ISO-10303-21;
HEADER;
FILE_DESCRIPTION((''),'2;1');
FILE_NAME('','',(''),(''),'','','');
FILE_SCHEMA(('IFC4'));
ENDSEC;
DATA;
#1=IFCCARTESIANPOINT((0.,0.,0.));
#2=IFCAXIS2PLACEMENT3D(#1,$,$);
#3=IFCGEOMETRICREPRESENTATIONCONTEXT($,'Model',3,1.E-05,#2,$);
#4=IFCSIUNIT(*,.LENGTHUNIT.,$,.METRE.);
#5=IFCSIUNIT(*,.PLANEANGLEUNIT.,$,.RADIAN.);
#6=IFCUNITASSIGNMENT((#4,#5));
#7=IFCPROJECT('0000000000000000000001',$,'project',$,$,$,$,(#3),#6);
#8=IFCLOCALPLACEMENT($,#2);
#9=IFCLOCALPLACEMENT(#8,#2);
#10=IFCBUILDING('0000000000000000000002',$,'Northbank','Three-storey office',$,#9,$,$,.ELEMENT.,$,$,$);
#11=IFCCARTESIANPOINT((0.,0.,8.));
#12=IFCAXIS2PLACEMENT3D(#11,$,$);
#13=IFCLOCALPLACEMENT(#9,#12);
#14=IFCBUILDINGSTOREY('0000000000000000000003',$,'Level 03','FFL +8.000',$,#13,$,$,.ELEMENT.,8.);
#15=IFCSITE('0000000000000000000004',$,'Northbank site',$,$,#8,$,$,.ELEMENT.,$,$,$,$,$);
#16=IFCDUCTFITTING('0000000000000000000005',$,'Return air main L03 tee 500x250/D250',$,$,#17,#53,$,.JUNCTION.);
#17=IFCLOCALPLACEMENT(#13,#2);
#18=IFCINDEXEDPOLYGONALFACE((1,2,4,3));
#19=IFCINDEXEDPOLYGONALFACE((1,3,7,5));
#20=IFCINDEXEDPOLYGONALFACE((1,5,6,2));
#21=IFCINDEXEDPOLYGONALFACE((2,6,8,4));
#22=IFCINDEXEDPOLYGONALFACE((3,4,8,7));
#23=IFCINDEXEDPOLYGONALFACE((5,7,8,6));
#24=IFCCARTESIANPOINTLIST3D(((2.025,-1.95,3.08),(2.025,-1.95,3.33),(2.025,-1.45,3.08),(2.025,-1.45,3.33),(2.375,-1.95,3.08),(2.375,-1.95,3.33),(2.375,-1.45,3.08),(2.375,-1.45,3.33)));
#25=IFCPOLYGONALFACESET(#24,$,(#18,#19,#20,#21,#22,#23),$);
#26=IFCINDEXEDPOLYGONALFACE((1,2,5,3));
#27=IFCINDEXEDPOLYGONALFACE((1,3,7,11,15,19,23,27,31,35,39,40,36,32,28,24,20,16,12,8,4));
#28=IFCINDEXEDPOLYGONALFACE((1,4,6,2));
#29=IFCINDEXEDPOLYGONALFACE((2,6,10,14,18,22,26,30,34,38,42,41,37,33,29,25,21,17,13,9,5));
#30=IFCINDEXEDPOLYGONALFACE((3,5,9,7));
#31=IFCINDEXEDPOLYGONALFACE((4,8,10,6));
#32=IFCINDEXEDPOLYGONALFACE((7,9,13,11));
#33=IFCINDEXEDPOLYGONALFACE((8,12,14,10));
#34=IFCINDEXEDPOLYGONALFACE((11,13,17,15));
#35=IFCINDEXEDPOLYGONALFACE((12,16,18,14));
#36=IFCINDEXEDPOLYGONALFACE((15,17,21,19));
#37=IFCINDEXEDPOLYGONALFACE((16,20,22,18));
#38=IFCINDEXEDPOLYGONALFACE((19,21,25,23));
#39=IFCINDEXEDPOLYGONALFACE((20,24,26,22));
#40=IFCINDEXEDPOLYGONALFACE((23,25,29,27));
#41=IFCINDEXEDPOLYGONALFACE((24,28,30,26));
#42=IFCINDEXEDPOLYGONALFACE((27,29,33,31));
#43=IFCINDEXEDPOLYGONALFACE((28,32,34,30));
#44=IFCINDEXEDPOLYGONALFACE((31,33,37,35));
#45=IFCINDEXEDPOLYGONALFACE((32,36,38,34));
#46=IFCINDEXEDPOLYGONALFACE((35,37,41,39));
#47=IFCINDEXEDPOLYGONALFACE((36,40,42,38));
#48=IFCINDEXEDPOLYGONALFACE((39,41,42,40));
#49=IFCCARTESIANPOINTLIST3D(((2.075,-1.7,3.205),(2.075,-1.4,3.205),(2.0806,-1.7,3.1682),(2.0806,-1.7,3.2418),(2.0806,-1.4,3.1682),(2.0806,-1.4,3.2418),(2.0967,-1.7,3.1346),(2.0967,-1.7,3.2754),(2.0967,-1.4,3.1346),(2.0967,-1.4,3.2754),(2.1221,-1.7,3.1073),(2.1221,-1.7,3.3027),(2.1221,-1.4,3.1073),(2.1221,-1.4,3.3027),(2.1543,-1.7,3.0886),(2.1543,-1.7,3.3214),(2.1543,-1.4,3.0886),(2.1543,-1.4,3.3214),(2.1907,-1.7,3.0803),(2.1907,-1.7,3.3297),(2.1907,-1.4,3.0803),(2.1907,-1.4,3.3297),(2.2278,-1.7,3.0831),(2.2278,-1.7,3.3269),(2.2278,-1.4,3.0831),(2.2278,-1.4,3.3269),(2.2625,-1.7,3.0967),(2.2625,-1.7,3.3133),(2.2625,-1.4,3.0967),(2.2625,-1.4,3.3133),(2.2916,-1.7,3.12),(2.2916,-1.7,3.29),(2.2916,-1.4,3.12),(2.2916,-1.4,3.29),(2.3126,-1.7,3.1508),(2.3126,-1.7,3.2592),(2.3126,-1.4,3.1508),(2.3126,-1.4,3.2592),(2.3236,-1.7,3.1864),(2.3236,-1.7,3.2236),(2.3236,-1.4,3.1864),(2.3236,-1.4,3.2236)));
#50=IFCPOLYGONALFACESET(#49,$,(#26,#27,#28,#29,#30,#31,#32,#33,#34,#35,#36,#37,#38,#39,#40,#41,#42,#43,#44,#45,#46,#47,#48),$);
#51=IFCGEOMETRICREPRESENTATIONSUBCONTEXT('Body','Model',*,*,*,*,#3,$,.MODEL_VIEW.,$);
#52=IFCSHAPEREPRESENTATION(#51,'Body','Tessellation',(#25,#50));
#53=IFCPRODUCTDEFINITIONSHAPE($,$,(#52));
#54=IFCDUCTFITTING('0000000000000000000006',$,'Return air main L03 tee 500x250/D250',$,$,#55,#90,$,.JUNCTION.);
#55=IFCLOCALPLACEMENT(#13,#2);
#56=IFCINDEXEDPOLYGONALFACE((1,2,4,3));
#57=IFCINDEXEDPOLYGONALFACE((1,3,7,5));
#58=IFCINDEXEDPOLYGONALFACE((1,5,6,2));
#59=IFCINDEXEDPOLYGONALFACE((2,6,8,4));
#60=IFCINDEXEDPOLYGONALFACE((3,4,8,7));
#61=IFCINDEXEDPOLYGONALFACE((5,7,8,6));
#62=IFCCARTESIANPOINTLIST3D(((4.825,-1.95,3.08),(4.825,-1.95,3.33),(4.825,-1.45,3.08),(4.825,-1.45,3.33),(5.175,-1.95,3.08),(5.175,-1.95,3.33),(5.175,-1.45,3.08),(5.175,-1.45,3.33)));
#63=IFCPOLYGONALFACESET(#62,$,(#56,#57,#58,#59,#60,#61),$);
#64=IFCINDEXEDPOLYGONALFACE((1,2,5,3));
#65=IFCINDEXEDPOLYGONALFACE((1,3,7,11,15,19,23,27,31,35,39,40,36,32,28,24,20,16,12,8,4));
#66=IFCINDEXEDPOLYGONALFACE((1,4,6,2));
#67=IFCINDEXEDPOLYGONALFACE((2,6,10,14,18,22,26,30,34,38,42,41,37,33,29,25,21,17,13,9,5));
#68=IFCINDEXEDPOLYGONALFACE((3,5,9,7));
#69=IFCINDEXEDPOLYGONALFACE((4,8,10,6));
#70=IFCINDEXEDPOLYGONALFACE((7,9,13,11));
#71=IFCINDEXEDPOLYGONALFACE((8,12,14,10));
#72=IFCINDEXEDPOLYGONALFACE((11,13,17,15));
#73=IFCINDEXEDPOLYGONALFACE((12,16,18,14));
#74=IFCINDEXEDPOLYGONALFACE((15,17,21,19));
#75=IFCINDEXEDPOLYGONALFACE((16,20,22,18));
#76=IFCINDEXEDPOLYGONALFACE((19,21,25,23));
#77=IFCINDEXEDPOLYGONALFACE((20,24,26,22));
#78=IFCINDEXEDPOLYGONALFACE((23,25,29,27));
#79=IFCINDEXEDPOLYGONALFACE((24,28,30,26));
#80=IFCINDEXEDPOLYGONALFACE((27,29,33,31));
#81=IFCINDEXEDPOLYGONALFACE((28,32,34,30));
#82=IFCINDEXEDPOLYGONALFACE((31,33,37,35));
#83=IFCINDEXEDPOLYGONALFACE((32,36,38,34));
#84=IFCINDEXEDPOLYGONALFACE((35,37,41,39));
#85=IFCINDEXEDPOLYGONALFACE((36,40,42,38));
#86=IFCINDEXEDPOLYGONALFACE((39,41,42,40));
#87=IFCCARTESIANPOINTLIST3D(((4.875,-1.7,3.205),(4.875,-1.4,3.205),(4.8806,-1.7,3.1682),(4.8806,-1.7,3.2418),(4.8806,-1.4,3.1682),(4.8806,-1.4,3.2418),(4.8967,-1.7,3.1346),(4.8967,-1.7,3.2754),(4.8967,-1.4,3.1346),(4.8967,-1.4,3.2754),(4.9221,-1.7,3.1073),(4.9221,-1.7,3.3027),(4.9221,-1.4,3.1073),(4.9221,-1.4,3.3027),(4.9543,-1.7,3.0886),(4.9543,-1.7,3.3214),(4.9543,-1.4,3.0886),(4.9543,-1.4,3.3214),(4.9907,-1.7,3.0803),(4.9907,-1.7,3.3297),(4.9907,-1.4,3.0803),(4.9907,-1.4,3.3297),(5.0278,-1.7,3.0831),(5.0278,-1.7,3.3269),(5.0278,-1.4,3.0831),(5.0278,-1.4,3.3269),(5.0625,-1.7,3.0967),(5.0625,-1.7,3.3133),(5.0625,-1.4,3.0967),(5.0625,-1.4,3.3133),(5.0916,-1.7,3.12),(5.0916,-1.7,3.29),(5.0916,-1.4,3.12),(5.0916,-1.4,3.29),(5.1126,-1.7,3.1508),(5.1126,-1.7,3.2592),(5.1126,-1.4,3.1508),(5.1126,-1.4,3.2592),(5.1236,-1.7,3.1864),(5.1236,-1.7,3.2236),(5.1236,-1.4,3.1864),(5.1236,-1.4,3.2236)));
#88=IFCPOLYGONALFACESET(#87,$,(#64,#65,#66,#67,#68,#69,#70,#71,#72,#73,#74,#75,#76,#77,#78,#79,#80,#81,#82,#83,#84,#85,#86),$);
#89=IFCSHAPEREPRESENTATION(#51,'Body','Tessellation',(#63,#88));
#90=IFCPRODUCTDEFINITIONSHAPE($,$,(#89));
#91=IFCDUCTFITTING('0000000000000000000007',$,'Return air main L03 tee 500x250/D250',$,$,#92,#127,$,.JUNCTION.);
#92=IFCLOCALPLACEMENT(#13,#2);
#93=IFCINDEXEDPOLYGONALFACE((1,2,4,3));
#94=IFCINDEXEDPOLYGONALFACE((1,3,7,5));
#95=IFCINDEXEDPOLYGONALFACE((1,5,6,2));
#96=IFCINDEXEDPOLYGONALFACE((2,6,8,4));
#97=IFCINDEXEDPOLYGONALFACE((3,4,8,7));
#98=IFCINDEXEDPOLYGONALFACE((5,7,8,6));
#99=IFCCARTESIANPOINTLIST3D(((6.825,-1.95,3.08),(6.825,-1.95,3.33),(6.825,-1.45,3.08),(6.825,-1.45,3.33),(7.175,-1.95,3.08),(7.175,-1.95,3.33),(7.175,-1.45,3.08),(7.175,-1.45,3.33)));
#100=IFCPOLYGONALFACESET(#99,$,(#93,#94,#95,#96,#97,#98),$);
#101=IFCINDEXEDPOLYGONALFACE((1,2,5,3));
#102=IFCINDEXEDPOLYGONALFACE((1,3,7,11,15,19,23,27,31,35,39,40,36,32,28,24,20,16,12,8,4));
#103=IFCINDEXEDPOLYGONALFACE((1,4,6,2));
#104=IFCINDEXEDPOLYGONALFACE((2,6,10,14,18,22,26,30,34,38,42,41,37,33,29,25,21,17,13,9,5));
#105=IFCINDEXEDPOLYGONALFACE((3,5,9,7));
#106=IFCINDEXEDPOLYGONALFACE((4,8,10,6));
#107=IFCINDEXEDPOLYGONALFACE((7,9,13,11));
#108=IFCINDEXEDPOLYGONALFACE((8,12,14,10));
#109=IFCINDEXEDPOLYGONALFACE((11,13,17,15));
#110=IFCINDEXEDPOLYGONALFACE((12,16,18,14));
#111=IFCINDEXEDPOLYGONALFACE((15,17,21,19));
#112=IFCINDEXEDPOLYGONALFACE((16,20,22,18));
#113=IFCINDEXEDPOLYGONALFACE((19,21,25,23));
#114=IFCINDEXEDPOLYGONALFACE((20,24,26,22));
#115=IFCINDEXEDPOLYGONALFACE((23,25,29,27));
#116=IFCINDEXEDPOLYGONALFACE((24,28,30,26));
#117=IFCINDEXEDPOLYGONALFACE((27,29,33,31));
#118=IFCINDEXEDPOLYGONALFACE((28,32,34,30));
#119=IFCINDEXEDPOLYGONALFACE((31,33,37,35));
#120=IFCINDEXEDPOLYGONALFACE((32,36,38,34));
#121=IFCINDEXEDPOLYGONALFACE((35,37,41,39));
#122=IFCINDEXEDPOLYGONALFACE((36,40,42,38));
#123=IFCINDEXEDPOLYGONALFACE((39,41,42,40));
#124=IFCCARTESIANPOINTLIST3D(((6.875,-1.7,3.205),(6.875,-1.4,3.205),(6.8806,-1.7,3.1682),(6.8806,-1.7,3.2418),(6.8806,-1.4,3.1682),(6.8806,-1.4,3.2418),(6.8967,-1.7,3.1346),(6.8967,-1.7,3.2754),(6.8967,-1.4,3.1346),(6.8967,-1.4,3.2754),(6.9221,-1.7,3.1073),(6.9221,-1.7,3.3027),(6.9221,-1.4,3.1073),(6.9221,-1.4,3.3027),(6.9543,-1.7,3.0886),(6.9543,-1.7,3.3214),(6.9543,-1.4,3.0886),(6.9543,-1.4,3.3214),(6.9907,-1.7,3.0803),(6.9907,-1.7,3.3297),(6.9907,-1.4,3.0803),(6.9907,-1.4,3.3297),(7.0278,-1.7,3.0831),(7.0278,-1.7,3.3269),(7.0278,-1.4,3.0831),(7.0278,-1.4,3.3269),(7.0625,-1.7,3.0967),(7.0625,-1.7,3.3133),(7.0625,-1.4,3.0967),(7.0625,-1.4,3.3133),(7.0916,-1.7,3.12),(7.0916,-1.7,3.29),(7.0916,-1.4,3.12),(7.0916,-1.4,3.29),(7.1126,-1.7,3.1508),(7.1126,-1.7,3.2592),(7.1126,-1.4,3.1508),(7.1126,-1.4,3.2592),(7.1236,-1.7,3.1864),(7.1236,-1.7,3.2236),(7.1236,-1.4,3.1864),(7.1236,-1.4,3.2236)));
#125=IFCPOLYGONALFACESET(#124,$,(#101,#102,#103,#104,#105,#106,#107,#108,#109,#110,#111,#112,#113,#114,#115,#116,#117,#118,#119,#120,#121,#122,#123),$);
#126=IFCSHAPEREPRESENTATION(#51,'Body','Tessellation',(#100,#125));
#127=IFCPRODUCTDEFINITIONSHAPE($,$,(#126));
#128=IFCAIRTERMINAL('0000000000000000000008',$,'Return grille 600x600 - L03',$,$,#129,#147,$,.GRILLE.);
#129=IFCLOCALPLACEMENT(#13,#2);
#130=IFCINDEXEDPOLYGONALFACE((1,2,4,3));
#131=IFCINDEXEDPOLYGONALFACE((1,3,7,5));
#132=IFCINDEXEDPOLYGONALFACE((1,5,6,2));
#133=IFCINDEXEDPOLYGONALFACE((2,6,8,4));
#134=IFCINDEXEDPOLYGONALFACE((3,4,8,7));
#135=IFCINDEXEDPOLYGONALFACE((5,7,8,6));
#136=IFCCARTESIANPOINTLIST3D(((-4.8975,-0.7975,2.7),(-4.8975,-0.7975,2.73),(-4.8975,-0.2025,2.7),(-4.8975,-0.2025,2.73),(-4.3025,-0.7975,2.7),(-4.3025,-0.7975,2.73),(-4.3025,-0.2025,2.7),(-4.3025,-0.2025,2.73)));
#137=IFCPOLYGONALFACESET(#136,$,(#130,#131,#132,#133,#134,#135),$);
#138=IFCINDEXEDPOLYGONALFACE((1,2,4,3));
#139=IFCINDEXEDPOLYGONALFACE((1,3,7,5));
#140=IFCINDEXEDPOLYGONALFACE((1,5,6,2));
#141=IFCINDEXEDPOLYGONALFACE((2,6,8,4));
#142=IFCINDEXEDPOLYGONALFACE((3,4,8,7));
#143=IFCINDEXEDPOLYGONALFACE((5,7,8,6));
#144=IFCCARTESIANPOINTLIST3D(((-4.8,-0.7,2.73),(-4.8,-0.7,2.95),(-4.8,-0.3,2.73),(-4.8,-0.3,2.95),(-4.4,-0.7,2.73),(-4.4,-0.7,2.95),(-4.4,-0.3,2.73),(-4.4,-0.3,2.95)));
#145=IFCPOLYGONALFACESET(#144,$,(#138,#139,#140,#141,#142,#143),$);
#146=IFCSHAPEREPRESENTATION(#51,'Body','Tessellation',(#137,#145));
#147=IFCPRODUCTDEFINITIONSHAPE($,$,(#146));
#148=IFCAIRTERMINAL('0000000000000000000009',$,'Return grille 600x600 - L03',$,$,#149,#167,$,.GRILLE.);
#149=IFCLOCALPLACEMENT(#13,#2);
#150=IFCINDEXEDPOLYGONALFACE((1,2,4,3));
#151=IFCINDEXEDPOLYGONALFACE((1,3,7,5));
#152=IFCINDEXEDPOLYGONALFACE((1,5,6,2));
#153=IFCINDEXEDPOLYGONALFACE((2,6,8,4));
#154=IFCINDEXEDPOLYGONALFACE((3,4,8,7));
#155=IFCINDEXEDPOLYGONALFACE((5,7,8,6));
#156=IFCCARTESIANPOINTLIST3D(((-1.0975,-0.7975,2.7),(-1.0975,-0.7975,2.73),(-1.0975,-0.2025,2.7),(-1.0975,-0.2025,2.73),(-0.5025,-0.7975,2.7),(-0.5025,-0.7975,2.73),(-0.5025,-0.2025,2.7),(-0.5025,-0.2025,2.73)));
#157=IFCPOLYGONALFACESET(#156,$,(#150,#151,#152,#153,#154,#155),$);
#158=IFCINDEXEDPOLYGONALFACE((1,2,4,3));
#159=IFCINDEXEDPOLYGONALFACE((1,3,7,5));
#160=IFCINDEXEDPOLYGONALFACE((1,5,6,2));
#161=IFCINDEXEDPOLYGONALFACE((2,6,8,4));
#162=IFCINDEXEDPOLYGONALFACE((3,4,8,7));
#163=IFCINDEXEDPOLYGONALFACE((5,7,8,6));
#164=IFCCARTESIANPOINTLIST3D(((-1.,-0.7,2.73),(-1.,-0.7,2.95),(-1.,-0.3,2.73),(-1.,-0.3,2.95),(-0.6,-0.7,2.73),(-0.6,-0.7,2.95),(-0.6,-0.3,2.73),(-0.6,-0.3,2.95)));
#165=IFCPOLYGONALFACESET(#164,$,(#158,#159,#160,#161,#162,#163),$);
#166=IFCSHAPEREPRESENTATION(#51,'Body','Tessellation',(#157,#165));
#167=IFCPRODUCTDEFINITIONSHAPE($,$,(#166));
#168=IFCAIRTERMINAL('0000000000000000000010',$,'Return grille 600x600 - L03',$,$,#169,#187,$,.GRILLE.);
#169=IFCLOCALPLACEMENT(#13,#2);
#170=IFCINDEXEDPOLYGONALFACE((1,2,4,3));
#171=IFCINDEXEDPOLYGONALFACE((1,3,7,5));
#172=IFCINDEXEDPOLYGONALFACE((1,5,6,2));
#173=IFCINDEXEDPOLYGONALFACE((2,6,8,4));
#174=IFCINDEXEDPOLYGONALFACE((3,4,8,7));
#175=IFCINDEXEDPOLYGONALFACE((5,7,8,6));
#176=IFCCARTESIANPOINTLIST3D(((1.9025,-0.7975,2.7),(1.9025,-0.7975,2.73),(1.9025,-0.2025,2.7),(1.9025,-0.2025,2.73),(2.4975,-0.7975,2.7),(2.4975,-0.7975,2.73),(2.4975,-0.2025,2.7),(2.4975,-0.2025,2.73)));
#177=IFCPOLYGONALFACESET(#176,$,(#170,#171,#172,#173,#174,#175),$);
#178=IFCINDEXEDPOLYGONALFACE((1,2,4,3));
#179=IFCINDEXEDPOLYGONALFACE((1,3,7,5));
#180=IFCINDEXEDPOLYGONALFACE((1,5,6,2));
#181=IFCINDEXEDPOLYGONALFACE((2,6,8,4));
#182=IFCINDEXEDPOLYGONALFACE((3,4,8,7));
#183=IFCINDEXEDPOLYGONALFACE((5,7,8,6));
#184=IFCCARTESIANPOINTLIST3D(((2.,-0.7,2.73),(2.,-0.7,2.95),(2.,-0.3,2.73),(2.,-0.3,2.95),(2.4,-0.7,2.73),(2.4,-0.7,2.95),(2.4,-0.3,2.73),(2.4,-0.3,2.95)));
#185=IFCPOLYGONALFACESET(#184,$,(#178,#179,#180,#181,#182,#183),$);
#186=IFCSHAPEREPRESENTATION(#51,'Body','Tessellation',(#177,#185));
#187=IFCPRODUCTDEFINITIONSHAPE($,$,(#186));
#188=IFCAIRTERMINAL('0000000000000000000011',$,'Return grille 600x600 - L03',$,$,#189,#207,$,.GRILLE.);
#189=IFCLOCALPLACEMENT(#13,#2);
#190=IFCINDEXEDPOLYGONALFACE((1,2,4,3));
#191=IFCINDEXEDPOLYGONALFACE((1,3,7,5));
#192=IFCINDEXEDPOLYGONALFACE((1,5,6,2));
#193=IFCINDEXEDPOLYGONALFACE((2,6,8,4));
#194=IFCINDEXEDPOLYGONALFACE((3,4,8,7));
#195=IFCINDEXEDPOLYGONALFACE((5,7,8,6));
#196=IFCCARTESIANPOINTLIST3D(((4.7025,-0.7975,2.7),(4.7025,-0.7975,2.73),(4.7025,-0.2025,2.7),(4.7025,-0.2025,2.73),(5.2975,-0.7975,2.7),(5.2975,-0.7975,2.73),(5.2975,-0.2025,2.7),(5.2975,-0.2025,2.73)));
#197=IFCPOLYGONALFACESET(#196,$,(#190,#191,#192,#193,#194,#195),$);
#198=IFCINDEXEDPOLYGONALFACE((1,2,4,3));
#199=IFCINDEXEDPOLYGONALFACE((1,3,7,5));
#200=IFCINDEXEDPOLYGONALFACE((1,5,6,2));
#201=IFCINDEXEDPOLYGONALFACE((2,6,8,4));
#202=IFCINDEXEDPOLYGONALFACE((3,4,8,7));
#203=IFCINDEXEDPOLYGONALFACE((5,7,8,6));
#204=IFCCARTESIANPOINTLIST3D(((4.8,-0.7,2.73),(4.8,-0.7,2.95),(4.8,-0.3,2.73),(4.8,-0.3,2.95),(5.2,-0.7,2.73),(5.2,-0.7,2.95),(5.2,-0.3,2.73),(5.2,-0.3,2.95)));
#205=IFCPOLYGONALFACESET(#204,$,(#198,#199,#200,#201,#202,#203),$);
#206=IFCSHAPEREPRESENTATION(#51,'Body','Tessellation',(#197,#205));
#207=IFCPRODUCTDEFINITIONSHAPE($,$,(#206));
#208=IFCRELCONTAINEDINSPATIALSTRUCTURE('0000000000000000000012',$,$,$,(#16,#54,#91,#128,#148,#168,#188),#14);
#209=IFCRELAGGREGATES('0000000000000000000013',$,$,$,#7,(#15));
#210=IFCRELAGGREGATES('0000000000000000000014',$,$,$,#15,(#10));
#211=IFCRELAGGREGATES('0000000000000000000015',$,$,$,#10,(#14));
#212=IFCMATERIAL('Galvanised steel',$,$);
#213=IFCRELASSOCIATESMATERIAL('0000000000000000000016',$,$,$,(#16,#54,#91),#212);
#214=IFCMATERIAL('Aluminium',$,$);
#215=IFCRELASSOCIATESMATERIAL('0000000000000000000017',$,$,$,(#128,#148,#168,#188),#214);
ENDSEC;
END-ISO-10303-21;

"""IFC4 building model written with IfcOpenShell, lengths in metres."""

from ifc_helpers import new_model, si_unit, frame, origin, place, context, subcontext, project, spatial, rectangle, circle, extrude, material, element, save


model = new_model("IFC4")

# Units and contexts
model_context = context("Model", 3, precision=1e-05, world=origin())
body_context = subcontext(model_context, "Body", "Model", "MODEL_VIEW")
ifc_project = project(units=[si_unit("LENGTHUNIT", "METRE"), si_unit("PLANEANGLEUNIT", "RADIAN")], contexts=[model_context])

# Site, building, storey
site_placement = place(None, origin())
site = spatial("IfcSite", under=ifc_project, at=site_placement, Name="Northbank site", CompositionType="ELEMENT")
building_placement = place(site_placement, origin())
building = spatial("IfcBuilding", under=site, at=building_placement, Name="Northbank", Description="Three-storey office", CompositionType="ELEMENT")
storey_placement = place(building_placement, frame((0.0, 0.0, 8.0)))
storey = spatial("IfcBuildingStorey", under=building, at=storey_placement, Name="Level 03", Description="FFL +8.000", CompositionType="ELEMENT", Elevation=8.0)

# Duct fitting
ifc_material_1 = material(Name="Galvanised steel")
duct_fitting_1_placement = place(storey_placement, frame((0.0, 0.0, -8.0)))
element("IfcDuctFitting", 1, at=duct_fitting_1_placement, inside=storey, material=ifc_material_1, Name="Return air main L03 tee 500x250/D250", PredefinedType="JUNCTION", context=body_context, shape_type="SweptSolid", body=[
    extrude(rectangle(XDim=0.5, YDim=0.25), frame((2.025, -1.7, 11.205), z_axis=(1.0, 0.0, 0.0), x_axis=(0.0, 1.0, 0.0)), (0.0, 0.0, 1.0), 0.35),
    extrude(circle(Radius=0.125), frame((2.2, -1.7, 11.205), z_axis=(0.0, 1.0, 0.0), x_axis=(-1.0, 0.0, 0.0)), (0.0, 0.0, 1.0), 0.3),
])

# Duct fitting
duct_fitting_2_placement = place(storey_placement, frame((0.0, 0.0, -8.0)))
element("IfcDuctFitting", 2, at=duct_fitting_2_placement, inside=storey, material=ifc_material_1, Name="Return air main L03 tee 500x250/D250", PredefinedType="JUNCTION", context=body_context, shape_type="SweptSolid", body=[
    extrude(rectangle(XDim=0.5, YDim=0.25), frame((4.825, -1.7, 11.205), z_axis=(1.0, 0.0, 0.0), x_axis=(0.0, 1.0, 0.0)), (0.0, 0.0, 1.0), 0.35),
    extrude(circle(Radius=0.125), frame((5.0, -1.7, 11.205), z_axis=(0.0, 1.0, 0.0), x_axis=(-1.0, 0.0, 0.0)), (0.0, 0.0, 1.0), 0.3),
])

# Duct fitting
duct_fitting_3_placement = place(storey_placement, frame((0.0, 0.0, -8.0)))
element("IfcDuctFitting", 3, at=duct_fitting_3_placement, inside=storey, material=ifc_material_1, Name="Return air main L03 tee 500x250/D250", PredefinedType="JUNCTION", context=body_context, shape_type="SweptSolid", body=[
    extrude(rectangle(XDim=0.5, YDim=0.25), frame((6.825, -1.7, 11.205), z_axis=(1.0, 0.0, 0.0), x_axis=(0.0, 1.0, 0.0)), (0.0, 0.0, 1.0), 0.35),
    extrude(circle(Radius=0.125), frame((7.0, -1.7, 11.205), z_axis=(0.0, 1.0, 0.0), x_axis=(-1.0, 0.0, 0.0)), (0.0, 0.0, 1.0), 0.3),
])

# Air terminal
ifc_material_2 = material(Name="Aluminium")
air_terminal_1_placement = place(storey_placement, frame((0.0, 0.0, -8.0)))
element("IfcAirTerminal", 4, at=air_terminal_1_placement, inside=storey, material=ifc_material_2, Name="Return grille 600x600 - L03", PredefinedType="GRILLE", context=body_context, shape_type="SweptSolid", body=[
    extrude(rectangle(XDim=0.595, YDim=0.595), frame((-4.6, -0.5, 10.7)), (0.0, 0.0, 1.0), 0.03),
    extrude(rectangle(XDim=0.4, YDim=0.4), frame((-4.6, -0.5, 10.73)), (0.0, 0.0, 1.0), 0.22),
])

# Air terminal
air_terminal_2_placement = place(storey_placement, frame((0.0, 0.0, -8.0)))
element("IfcAirTerminal", 5, at=air_terminal_2_placement, inside=storey, material=ifc_material_2, Name="Return grille 600x600 - L03", PredefinedType="GRILLE", context=body_context, shape_type="SweptSolid", body=[
    extrude(rectangle(XDim=0.595, YDim=0.595), frame((-0.8, -0.5, 10.7)), (0.0, 0.0, 1.0), 0.03),
    extrude(rectangle(XDim=0.4, YDim=0.4), frame((-0.8, -0.5, 10.73)), (0.0, 0.0, 1.0), 0.22),
])

# Air terminal
air_terminal_3_placement = place(storey_placement, frame((0.0, 0.0, -8.0)))
element("IfcAirTerminal", 6, at=air_terminal_3_placement, inside=storey, material=ifc_material_2, Name="Return grille 600x600 - L03", PredefinedType="GRILLE", context=body_context, shape_type="SweptSolid", body=[
    extrude(rectangle(XDim=0.595, YDim=0.595), frame((2.2, -0.5, 10.7)), (0.0, 0.0, 1.0), 0.03),
    extrude(rectangle(XDim=0.4, YDim=0.4), frame((2.2, -0.5, 10.73)), (0.0, 0.0, 1.0), 0.22),
])

# Air terminal
air_terminal_4_placement = place(storey_placement, frame((0.0, 0.0, -8.0)))
element("IfcAirTerminal", 7, at=air_terminal_4_placement, inside=storey, material=ifc_material_2, Name="Return grille 600x600 - L03", PredefinedType="GRILLE", context=body_context, shape_type="SweptSolid", body=[
    extrude(rectangle(XDim=0.595, YDim=0.595), frame((5.0, -0.5, 10.7)), (0.0, 0.0, 1.0), 0.03),
    extrude(rectangle(XDim=0.4, YDim=0.4), frame((5.0, -0.5, 10.73)), (0.0, 0.0, 1.0), 0.22),
])

save(model, "model.ifc")
